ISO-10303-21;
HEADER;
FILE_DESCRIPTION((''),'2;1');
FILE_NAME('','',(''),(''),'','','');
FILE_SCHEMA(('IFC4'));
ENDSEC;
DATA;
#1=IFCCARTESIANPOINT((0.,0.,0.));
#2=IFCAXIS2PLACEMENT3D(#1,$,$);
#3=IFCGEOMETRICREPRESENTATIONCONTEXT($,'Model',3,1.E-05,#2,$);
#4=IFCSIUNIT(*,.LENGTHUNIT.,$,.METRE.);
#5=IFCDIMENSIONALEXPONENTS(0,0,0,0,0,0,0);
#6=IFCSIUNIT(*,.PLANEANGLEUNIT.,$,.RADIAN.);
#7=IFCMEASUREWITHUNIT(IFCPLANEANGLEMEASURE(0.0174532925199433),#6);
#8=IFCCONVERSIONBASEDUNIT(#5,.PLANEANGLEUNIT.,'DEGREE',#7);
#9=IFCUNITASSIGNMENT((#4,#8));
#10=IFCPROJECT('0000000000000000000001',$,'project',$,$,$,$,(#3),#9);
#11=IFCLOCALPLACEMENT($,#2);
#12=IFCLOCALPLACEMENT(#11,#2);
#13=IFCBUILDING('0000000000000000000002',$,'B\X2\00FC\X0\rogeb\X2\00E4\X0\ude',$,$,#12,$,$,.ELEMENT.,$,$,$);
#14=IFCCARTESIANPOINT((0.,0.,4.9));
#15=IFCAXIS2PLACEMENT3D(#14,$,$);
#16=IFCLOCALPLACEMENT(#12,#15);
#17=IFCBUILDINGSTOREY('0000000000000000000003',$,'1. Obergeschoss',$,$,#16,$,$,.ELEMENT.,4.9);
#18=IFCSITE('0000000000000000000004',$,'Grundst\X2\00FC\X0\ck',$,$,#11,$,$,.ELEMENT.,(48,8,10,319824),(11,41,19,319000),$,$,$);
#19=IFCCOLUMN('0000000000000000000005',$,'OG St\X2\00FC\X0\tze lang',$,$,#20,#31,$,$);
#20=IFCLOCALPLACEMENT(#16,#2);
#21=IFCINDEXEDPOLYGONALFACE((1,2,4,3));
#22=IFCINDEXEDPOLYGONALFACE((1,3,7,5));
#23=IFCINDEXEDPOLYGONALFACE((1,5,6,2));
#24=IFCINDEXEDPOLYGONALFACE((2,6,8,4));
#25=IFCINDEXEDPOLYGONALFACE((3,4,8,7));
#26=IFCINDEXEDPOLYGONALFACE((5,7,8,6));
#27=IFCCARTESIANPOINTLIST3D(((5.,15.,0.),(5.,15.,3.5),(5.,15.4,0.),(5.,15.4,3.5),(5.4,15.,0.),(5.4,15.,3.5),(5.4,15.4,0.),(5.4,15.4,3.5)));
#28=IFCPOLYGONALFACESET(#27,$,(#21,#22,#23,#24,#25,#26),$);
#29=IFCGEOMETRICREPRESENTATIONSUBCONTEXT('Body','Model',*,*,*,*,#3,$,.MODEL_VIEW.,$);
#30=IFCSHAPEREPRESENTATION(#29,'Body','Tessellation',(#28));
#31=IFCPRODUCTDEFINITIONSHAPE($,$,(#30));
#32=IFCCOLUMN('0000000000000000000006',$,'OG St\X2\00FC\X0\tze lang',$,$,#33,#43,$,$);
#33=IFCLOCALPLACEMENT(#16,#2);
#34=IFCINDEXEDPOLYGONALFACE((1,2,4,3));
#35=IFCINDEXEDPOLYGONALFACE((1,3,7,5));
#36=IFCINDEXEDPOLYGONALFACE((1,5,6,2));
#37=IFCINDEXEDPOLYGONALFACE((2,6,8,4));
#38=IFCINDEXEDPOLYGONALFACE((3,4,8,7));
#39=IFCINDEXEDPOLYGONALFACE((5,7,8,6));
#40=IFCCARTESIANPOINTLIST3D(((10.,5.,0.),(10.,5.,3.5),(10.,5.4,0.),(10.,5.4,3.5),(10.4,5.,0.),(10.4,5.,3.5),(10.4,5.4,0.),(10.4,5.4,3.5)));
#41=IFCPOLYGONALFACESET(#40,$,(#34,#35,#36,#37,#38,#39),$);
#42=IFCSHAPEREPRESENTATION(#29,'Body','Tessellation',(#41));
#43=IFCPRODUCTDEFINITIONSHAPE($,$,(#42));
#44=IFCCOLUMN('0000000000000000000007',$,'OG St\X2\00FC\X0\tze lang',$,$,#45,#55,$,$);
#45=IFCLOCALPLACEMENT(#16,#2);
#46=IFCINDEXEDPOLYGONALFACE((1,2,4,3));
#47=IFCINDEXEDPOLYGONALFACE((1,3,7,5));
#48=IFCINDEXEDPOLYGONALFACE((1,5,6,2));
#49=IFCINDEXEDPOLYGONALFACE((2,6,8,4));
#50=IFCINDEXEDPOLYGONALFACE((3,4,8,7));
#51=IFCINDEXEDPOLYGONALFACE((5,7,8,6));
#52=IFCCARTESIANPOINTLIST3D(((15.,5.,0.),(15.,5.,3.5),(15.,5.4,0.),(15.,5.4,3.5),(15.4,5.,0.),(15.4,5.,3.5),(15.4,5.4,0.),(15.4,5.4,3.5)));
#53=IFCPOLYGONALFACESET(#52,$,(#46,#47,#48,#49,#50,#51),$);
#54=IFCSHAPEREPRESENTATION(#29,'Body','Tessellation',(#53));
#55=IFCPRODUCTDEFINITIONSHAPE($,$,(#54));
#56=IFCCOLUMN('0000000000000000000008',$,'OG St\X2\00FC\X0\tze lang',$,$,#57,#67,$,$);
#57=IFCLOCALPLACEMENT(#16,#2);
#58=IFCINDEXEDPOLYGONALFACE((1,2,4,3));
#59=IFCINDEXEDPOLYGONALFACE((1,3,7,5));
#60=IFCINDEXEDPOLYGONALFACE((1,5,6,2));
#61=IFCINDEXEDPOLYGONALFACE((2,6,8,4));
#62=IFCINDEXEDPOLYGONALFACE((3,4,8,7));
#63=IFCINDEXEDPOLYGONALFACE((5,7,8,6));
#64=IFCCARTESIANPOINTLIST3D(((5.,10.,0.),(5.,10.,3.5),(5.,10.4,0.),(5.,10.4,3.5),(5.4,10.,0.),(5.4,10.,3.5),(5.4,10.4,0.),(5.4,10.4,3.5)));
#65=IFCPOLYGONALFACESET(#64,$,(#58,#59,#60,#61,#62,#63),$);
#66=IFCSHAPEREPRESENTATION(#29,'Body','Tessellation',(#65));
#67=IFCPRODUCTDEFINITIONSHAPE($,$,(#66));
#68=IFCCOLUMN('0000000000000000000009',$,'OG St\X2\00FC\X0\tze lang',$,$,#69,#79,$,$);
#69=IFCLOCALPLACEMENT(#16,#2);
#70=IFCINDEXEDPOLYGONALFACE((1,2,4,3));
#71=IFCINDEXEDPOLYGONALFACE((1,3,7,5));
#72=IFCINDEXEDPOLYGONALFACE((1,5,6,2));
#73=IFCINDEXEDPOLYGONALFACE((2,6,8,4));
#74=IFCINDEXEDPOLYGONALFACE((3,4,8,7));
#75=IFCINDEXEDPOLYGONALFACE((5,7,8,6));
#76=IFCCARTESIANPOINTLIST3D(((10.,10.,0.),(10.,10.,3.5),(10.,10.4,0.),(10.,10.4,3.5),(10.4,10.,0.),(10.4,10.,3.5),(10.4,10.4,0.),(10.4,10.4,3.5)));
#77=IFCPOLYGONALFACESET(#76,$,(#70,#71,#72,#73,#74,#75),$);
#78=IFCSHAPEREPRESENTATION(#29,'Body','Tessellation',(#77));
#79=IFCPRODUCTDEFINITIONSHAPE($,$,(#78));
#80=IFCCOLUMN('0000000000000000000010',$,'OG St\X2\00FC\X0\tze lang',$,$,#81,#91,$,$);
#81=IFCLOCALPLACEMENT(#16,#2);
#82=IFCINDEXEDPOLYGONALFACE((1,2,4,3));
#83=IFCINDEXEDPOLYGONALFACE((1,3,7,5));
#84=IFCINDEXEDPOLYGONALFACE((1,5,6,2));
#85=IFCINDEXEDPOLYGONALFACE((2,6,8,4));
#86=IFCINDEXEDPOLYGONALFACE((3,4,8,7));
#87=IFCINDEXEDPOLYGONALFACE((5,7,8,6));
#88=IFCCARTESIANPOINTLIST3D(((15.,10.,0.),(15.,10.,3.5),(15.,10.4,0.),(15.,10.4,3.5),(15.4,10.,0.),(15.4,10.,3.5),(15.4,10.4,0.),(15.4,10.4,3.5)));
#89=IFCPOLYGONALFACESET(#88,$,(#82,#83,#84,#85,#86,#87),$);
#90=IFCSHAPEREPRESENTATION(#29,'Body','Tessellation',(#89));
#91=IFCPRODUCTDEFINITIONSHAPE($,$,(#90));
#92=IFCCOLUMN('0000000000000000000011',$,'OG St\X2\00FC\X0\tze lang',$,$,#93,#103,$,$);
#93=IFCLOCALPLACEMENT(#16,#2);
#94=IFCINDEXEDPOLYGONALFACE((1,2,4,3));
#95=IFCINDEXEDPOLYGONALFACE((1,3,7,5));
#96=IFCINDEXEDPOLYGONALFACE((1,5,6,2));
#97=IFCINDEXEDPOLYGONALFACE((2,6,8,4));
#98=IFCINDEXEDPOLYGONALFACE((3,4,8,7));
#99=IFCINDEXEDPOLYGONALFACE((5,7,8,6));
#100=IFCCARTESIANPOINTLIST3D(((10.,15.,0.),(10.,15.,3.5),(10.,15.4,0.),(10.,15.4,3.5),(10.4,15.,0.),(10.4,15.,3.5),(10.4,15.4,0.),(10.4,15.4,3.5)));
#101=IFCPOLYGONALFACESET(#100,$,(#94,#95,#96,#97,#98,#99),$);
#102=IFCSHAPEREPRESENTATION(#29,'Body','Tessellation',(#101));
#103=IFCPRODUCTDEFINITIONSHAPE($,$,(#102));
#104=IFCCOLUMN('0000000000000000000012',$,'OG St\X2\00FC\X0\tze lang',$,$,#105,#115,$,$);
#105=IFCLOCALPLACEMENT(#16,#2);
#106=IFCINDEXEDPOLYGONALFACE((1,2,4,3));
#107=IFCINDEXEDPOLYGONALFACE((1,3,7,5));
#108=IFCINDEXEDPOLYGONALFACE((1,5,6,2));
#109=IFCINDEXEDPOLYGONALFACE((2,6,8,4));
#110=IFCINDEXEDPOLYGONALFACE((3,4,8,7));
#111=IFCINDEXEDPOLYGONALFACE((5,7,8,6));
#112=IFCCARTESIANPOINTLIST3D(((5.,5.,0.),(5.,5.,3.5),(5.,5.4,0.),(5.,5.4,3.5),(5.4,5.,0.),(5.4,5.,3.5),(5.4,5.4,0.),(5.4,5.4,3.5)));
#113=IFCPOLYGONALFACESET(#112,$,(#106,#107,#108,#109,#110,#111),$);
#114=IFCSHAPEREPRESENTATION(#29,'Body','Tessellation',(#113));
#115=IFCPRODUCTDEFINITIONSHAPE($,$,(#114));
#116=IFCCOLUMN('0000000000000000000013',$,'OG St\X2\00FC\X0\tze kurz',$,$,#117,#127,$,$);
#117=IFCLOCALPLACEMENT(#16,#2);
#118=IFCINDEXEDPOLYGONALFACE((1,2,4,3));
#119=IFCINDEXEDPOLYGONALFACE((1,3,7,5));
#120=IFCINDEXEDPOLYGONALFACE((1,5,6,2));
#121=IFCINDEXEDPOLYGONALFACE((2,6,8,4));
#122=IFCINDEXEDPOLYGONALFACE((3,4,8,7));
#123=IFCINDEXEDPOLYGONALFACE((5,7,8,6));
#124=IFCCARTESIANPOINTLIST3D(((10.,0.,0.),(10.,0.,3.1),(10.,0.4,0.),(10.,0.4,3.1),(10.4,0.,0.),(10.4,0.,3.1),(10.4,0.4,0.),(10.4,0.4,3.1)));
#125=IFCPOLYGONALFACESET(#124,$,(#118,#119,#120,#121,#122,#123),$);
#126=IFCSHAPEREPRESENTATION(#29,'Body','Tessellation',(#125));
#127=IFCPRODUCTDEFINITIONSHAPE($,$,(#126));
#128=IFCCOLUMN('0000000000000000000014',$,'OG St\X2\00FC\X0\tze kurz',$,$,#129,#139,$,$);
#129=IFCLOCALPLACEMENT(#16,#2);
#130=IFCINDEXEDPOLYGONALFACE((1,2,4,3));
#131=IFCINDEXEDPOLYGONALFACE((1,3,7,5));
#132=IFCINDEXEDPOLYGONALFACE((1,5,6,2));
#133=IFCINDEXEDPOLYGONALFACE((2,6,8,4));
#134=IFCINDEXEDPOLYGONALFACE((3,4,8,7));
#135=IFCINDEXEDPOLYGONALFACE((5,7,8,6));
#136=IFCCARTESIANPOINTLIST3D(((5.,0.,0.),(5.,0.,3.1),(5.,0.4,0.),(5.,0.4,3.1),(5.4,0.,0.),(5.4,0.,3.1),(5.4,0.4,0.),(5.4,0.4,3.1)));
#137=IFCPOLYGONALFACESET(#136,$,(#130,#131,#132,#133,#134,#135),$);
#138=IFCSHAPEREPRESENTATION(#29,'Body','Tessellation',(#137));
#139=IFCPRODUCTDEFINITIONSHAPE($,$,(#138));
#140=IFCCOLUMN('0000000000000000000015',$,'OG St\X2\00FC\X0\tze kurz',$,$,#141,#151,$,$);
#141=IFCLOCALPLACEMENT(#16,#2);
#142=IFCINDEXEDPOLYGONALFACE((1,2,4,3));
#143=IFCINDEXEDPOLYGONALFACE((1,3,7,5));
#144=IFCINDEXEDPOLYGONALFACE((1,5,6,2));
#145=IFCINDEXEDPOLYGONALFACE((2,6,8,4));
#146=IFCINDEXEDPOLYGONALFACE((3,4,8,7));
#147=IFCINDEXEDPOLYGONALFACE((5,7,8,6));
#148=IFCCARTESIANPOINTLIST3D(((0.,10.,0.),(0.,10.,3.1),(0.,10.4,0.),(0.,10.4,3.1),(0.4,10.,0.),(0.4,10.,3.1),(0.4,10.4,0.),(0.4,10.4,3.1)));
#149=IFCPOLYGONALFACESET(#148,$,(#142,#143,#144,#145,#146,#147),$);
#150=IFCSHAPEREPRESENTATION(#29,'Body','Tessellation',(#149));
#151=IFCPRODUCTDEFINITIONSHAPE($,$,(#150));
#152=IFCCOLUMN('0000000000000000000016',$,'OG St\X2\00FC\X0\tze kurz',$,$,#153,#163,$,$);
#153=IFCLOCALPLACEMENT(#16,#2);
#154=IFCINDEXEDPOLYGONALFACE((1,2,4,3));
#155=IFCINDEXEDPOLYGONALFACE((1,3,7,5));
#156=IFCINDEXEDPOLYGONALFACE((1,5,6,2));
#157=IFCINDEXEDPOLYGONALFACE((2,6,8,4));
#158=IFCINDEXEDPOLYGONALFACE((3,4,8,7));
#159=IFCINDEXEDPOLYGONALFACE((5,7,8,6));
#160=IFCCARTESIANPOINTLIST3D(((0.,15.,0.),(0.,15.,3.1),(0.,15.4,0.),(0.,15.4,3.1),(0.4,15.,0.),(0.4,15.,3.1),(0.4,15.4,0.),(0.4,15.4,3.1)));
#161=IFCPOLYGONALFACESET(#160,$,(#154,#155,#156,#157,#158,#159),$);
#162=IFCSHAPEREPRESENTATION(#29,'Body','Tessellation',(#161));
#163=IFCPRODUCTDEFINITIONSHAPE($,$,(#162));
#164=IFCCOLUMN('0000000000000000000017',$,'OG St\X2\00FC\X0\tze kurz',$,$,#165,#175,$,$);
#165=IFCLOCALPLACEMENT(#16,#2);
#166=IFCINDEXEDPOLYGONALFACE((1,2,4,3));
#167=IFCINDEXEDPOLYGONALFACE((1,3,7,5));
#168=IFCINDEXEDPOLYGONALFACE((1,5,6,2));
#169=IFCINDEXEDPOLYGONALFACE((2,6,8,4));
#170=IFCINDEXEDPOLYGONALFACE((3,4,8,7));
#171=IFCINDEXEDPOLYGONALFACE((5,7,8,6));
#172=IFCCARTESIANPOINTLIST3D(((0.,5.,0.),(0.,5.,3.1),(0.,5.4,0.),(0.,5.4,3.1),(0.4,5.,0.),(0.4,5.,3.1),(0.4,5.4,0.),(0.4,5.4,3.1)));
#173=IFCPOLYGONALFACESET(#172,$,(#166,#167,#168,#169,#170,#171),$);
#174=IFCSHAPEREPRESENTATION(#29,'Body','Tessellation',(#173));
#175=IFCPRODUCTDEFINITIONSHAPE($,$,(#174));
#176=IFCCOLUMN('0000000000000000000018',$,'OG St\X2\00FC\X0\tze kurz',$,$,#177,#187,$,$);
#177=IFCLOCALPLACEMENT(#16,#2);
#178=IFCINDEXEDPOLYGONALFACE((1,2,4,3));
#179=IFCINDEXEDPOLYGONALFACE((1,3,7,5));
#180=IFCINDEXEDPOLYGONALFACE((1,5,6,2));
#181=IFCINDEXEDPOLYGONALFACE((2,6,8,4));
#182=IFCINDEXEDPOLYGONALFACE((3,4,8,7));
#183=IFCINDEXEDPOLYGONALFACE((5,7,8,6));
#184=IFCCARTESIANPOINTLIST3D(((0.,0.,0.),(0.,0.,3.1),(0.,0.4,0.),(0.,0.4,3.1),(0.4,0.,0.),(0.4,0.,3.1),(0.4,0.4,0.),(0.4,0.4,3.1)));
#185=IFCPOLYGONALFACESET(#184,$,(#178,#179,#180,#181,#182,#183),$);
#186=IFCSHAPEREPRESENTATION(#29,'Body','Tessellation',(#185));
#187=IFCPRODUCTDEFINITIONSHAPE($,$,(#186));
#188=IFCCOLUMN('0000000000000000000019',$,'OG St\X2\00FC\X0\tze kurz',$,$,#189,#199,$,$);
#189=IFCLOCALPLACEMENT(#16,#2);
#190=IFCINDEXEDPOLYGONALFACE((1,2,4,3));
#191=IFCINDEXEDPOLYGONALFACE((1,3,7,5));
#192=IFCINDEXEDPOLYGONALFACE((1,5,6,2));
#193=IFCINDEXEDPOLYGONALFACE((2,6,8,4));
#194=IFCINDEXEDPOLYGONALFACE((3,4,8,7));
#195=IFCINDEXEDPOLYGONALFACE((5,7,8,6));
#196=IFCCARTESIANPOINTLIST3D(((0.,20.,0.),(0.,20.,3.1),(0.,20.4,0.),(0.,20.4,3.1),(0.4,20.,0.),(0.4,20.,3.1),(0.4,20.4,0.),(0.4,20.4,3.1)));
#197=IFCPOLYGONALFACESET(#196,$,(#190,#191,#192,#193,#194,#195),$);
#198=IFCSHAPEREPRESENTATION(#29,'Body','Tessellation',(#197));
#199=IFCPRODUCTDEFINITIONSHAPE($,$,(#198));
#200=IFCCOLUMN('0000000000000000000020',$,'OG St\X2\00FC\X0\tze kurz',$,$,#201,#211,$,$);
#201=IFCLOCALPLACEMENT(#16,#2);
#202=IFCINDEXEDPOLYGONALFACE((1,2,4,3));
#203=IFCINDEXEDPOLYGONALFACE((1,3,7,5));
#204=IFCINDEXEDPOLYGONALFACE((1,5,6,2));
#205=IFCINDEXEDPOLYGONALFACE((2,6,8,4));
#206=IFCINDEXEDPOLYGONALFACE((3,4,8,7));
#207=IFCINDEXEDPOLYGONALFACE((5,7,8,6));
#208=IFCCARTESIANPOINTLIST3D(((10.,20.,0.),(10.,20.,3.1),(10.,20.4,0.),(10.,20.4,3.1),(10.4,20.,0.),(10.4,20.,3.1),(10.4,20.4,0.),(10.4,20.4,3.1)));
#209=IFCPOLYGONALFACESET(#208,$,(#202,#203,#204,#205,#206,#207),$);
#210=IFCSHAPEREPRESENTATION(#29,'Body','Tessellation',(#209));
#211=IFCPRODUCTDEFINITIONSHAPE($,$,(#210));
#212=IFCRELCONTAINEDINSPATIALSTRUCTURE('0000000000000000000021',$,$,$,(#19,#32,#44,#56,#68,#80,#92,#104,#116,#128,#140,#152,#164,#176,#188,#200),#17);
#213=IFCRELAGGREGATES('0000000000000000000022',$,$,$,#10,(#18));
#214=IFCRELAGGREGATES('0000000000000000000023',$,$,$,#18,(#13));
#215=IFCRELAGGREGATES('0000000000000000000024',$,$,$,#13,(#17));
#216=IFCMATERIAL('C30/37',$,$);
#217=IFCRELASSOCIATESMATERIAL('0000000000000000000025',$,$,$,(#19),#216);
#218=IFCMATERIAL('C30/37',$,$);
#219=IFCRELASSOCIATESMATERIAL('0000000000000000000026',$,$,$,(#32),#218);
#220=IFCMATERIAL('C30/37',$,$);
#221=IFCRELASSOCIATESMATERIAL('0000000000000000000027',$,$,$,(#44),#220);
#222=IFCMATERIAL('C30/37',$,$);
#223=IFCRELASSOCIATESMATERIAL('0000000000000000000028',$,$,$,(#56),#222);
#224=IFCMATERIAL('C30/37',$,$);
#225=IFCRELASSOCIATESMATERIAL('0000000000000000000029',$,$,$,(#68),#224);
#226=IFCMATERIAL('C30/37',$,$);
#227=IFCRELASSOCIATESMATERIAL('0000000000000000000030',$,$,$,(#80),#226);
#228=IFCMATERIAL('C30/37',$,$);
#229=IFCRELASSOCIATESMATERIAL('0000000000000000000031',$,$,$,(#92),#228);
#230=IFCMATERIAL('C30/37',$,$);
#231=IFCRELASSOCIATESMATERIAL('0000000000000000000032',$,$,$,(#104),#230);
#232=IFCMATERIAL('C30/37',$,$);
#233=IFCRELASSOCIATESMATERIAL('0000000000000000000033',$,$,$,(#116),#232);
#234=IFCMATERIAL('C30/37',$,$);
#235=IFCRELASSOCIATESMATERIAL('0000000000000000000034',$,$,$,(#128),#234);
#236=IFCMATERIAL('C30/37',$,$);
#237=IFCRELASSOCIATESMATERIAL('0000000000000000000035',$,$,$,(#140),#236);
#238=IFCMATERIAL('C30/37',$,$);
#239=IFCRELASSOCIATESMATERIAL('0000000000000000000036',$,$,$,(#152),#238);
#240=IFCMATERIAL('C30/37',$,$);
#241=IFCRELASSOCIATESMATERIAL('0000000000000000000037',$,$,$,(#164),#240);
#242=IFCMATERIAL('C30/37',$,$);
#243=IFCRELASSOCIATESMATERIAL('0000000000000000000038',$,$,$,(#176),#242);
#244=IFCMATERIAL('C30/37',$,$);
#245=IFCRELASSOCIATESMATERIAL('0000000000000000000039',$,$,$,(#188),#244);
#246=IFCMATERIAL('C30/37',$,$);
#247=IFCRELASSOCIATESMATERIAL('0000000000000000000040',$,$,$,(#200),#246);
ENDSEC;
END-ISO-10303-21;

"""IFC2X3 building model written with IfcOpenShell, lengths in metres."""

from ifc_helpers import new_model, entity, si_unit, converted_unit, frame, frame_2d, origin, origin_with_axes, place, context, subcontext, project, spatial, rectangle, extrude, material, element, save


model = new_model("IFC2X3")

# Units and contexts
model_context = context("Model", 3, precision=1e-05, world=origin())
body_context = subcontext(model_context, "Body", "Model", "MODEL_VIEW")
ifc_project = project(units=[si_unit("LENGTHUNIT", "METRE"), converted_unit("PLANEANGLEUNIT", "DEGREE", entity("IfcPlaneAngleMeasure", 0.0174532925199433), si_unit("PLANEANGLEUNIT", "RADIAN"), dimensions=[0, 0, 0, 0, 0, 0, 0])], contexts=[model_context])

# Site, building, storey
site_placement = place(None, origin())
site = spatial("IfcSite", under=ifc_project, at=site_placement, Name="Grundstück", CompositionType="ELEMENT", RefLatitude=(48, 8, 10, 319824), RefLongitude=(11, 41, 19, 319000))
building_placement = place(site_placement, origin())
building = spatial("IfcBuilding", under=site, at=building_placement, Name="Bürogebäude", CompositionType="ELEMENT")
storey_placement = place(building_placement, frame((0.0, 0.0, 4.9)))
storey = spatial("IfcBuildingStorey", under=building, at=storey_placement, Name="1. Obergeschoss", CompositionType="ELEMENT", Elevation=4.9)

# Columns
ifc_material_1 = material(Name="C30/37")
column_1_placement = place(storey_placement, frame((5.0, 15.0, 0.0)))
element("IfcColumn", 1, at=column_1_placement, inside=storey, material=ifc_material_1, Name="OG Stütze lang", context=body_context, shape_type="SweptSolid", body=[
    extrude(rectangle(XDim=0.4, YDim=0.4, at=frame_2d((0.2, 0.2), x_axis=(1.0, 0.0))), origin_with_axes(), (0.0, 0.0, 1.0), 3.5),
])
ifc_material_2 = material(Name="C30/37")
column_2_placement = place(storey_placement, frame((10.0, 5.0, 0.0)))
element("IfcColumn", 2, at=column_2_placement, inside=storey, material=ifc_material_2, Name="OG Stütze lang", context=body_context, shape_type="SweptSolid", body=[
    extrude(rectangle(XDim=0.4, YDim=0.4, at=frame_2d((0.2, 0.2), x_axis=(1.0, 0.0))), origin_with_axes(), (0.0, 0.0, 1.0), 3.5),
])
ifc_material_3 = material(Name="C30/37")
column_3_placement = place(storey_placement, frame((15.0, 5.0, 0.0)))
element("IfcColumn", 3, at=column_3_placement, inside=storey, material=ifc_material_3, Name="OG Stütze lang", context=body_context, shape_type="SweptSolid", body=[
    extrude(rectangle(XDim=0.4, YDim=0.4, at=frame_2d((0.2, 0.2), x_axis=(1.0, 0.0))), origin_with_axes(), (0.0, 0.0, 1.0), 3.5),
])
ifc_material_4 = material(Name="C30/37")
column_4_placement = place(storey_placement, frame((5.0, 10.0, 0.0)))
element("IfcColumn", 4, at=column_4_placement, inside=storey, material=ifc_material_4, Name="OG Stütze lang", context=body_context, shape_type="SweptSolid", body=[
    extrude(rectangle(XDim=0.4, YDim=0.4, at=frame_2d((0.2, 0.2), x_axis=(1.0, 0.0))), origin_with_axes(), (0.0, 0.0, 1.0), 3.5),
])
ifc_material_5 = material(Name="C30/37")
column_5_placement = place(storey_placement, frame((10.0, 10.0, 0.0)))
element("IfcColumn", 5, at=column_5_placement, inside=storey, material=ifc_material_5, Name="OG Stütze lang", context=body_context, shape_type="SweptSolid", body=[
    extrude(rectangle(XDim=0.4, YDim=0.4, at=frame_2d((0.2, 0.2), x_axis=(1.0, 0.0))), origin_with_axes(), (0.0, 0.0, 1.0), 3.5),
])
ifc_material_6 = material(Name="C30/37")
column_6_placement = place(storey_placement, frame((15.0, 10.0, 0.0)))
element("IfcColumn", 6, at=column_6_placement, inside=storey, material=ifc_material_6, Name="OG Stütze lang", context=body_context, shape_type="SweptSolid", body=[
    extrude(rectangle(XDim=0.4, YDim=0.4, at=frame_2d((0.2, 0.2), x_axis=(1.0, 0.0))), origin_with_axes(), (0.0, 0.0, 1.0), 3.5),
])
ifc_material_7 = material(Name="C30/37")
column_7_placement = place(storey_placement, frame((10.0, 15.0, 0.0)))
element("IfcColumn", 7, at=column_7_placement, inside=storey, material=ifc_material_7, Name="OG Stütze lang", context=body_context, shape_type="SweptSolid", body=[
    extrude(rectangle(XDim=0.4, YDim=0.4, at=frame_2d((0.2, 0.2), x_axis=(1.0, 0.0))), origin_with_axes(), (0.0, 0.0, 1.0), 3.5),
])
ifc_material_8 = material(Name="C30/37")
column_8_placement = place(storey_placement, frame((5.0, 5.0, 0.0)))
element("IfcColumn", 8, at=column_8_placement, inside=storey, material=ifc_material_8, Name="OG Stütze lang", context=body_context, shape_type="SweptSolid", body=[
    extrude(rectangle(XDim=0.4, YDim=0.4, at=frame_2d((0.2, 0.2), x_axis=(1.0, 0.0))), origin_with_axes(), (0.0, 0.0, 1.0), 3.5),
])
ifc_material_9 = material(Name="C30/37")
column_9_placement = place(storey_placement, frame((10.0, 0.0, 0.0)))
element("IfcColumn", 9, at=column_9_placement, inside=storey, material=ifc_material_9, Name="OG Stütze kurz", context=body_context, shape_type="SweptSolid", body=[
    extrude(rectangle(XDim=0.4, YDim=0.4, at=frame_2d((0.2, 0.2), x_axis=(1.0, 0.0))), origin_with_axes(), (0.0, 0.0, 1.0), 3.1),
])
ifc_material_10 = material(Name="C30/37")
column_10_placement = place(storey_placement, frame((5.0, 0.0, 0.0)))
element("IfcColumn", 10, at=column_10_placement, inside=storey, material=ifc_material_10, Name="OG Stütze kurz", context=body_context, shape_type="SweptSolid", body=[
    extrude(rectangle(XDim=0.4, YDim=0.4, at=frame_2d((0.2, 0.2), x_axis=(1.0, 0.0))), origin_with_axes(), (0.0, 0.0, 1.0), 3.1),
])
ifc_material_11 = material(Name="C30/37")
column_11_placement = place(storey_placement, frame((0.0, 10.0, 0.0)))
element("IfcColumn", 11, at=column_11_placement, inside=storey, material=ifc_material_11, Name="OG Stütze kurz", context=body_context, shape_type="SweptSolid", body=[
    extrude(rectangle(XDim=0.4, YDim=0.4, at=frame_2d((0.2, 0.2), x_axis=(1.0, 0.0))), origin_with_axes(), (0.0, 0.0, 1.0), 3.1),
])
ifc_material_12 = material(Name="C30/37")
column_12_placement = place(storey_placement, frame((0.0, 15.0, 0.0)))
element("IfcColumn", 12, at=column_12_placement, inside=storey, material=ifc_material_12, Name="OG Stütze kurz", context=body_context, shape_type="SweptSolid", body=[
    extrude(rectangle(XDim=0.4, YDim=0.4, at=frame_2d((0.2, 0.2), x_axis=(1.0, 0.0))), origin_with_axes(), (0.0, 0.0, 1.0), 3.1),
])
ifc_material_13 = material(Name="C30/37")
column_13_placement = place(storey_placement, frame((0.0, 5.0, 0.0)))
element("IfcColumn", 13, at=column_13_placement, inside=storey, material=ifc_material_13, Name="OG Stütze kurz", context=body_context, shape_type="SweptSolid", body=[
    extrude(rectangle(XDim=0.4, YDim=0.4, at=frame_2d((0.2, 0.2), x_axis=(1.0, 0.0))), origin_with_axes(), (0.0, 0.0, 1.0), 3.1),
])
ifc_material_14 = material(Name="C30/37")
column_14_placement = place(storey_placement, origin())
element("IfcColumn", 14, at=column_14_placement, inside=storey, material=ifc_material_14, Name="OG Stütze kurz", context=body_context, shape_type="SweptSolid", body=[
    extrude(rectangle(XDim=0.4, YDim=0.4, at=frame_2d((0.2, 0.2), x_axis=(1.0, 0.0))), origin_with_axes(), (0.0, 0.0, 1.0), 3.1),
])
ifc_material_15 = material(Name="C30/37")
column_15_placement = place(storey_placement, frame((0.0, 20.0, 0.0)))
element("IfcColumn", 15, at=column_15_placement, inside=storey, material=ifc_material_15, Name="OG Stütze kurz", context=body_context, shape_type="SweptSolid", body=[
    extrude(rectangle(XDim=0.4, YDim=0.4, at=frame_2d((0.2, 0.2), x_axis=(1.0, 0.0))), origin_with_axes(), (0.0, 0.0, 1.0), 3.1),
])
ifc_material_16 = material(Name="C30/37")
column_16_placement = place(storey_placement, frame((10.0, 20.0, 0.0)))
element("IfcColumn", 16, at=column_16_placement, inside=storey, material=ifc_material_16, Name="OG Stütze kurz", context=body_context, shape_type="SweptSolid", body=[
    extrude(rectangle(XDim=0.4, YDim=0.4, at=frame_2d((0.2, 0.2), x_axis=(1.0, 0.0))), origin_with_axes(), (0.0, 0.0, 1.0), 3.1),
])

save(model, "model.ifc")
